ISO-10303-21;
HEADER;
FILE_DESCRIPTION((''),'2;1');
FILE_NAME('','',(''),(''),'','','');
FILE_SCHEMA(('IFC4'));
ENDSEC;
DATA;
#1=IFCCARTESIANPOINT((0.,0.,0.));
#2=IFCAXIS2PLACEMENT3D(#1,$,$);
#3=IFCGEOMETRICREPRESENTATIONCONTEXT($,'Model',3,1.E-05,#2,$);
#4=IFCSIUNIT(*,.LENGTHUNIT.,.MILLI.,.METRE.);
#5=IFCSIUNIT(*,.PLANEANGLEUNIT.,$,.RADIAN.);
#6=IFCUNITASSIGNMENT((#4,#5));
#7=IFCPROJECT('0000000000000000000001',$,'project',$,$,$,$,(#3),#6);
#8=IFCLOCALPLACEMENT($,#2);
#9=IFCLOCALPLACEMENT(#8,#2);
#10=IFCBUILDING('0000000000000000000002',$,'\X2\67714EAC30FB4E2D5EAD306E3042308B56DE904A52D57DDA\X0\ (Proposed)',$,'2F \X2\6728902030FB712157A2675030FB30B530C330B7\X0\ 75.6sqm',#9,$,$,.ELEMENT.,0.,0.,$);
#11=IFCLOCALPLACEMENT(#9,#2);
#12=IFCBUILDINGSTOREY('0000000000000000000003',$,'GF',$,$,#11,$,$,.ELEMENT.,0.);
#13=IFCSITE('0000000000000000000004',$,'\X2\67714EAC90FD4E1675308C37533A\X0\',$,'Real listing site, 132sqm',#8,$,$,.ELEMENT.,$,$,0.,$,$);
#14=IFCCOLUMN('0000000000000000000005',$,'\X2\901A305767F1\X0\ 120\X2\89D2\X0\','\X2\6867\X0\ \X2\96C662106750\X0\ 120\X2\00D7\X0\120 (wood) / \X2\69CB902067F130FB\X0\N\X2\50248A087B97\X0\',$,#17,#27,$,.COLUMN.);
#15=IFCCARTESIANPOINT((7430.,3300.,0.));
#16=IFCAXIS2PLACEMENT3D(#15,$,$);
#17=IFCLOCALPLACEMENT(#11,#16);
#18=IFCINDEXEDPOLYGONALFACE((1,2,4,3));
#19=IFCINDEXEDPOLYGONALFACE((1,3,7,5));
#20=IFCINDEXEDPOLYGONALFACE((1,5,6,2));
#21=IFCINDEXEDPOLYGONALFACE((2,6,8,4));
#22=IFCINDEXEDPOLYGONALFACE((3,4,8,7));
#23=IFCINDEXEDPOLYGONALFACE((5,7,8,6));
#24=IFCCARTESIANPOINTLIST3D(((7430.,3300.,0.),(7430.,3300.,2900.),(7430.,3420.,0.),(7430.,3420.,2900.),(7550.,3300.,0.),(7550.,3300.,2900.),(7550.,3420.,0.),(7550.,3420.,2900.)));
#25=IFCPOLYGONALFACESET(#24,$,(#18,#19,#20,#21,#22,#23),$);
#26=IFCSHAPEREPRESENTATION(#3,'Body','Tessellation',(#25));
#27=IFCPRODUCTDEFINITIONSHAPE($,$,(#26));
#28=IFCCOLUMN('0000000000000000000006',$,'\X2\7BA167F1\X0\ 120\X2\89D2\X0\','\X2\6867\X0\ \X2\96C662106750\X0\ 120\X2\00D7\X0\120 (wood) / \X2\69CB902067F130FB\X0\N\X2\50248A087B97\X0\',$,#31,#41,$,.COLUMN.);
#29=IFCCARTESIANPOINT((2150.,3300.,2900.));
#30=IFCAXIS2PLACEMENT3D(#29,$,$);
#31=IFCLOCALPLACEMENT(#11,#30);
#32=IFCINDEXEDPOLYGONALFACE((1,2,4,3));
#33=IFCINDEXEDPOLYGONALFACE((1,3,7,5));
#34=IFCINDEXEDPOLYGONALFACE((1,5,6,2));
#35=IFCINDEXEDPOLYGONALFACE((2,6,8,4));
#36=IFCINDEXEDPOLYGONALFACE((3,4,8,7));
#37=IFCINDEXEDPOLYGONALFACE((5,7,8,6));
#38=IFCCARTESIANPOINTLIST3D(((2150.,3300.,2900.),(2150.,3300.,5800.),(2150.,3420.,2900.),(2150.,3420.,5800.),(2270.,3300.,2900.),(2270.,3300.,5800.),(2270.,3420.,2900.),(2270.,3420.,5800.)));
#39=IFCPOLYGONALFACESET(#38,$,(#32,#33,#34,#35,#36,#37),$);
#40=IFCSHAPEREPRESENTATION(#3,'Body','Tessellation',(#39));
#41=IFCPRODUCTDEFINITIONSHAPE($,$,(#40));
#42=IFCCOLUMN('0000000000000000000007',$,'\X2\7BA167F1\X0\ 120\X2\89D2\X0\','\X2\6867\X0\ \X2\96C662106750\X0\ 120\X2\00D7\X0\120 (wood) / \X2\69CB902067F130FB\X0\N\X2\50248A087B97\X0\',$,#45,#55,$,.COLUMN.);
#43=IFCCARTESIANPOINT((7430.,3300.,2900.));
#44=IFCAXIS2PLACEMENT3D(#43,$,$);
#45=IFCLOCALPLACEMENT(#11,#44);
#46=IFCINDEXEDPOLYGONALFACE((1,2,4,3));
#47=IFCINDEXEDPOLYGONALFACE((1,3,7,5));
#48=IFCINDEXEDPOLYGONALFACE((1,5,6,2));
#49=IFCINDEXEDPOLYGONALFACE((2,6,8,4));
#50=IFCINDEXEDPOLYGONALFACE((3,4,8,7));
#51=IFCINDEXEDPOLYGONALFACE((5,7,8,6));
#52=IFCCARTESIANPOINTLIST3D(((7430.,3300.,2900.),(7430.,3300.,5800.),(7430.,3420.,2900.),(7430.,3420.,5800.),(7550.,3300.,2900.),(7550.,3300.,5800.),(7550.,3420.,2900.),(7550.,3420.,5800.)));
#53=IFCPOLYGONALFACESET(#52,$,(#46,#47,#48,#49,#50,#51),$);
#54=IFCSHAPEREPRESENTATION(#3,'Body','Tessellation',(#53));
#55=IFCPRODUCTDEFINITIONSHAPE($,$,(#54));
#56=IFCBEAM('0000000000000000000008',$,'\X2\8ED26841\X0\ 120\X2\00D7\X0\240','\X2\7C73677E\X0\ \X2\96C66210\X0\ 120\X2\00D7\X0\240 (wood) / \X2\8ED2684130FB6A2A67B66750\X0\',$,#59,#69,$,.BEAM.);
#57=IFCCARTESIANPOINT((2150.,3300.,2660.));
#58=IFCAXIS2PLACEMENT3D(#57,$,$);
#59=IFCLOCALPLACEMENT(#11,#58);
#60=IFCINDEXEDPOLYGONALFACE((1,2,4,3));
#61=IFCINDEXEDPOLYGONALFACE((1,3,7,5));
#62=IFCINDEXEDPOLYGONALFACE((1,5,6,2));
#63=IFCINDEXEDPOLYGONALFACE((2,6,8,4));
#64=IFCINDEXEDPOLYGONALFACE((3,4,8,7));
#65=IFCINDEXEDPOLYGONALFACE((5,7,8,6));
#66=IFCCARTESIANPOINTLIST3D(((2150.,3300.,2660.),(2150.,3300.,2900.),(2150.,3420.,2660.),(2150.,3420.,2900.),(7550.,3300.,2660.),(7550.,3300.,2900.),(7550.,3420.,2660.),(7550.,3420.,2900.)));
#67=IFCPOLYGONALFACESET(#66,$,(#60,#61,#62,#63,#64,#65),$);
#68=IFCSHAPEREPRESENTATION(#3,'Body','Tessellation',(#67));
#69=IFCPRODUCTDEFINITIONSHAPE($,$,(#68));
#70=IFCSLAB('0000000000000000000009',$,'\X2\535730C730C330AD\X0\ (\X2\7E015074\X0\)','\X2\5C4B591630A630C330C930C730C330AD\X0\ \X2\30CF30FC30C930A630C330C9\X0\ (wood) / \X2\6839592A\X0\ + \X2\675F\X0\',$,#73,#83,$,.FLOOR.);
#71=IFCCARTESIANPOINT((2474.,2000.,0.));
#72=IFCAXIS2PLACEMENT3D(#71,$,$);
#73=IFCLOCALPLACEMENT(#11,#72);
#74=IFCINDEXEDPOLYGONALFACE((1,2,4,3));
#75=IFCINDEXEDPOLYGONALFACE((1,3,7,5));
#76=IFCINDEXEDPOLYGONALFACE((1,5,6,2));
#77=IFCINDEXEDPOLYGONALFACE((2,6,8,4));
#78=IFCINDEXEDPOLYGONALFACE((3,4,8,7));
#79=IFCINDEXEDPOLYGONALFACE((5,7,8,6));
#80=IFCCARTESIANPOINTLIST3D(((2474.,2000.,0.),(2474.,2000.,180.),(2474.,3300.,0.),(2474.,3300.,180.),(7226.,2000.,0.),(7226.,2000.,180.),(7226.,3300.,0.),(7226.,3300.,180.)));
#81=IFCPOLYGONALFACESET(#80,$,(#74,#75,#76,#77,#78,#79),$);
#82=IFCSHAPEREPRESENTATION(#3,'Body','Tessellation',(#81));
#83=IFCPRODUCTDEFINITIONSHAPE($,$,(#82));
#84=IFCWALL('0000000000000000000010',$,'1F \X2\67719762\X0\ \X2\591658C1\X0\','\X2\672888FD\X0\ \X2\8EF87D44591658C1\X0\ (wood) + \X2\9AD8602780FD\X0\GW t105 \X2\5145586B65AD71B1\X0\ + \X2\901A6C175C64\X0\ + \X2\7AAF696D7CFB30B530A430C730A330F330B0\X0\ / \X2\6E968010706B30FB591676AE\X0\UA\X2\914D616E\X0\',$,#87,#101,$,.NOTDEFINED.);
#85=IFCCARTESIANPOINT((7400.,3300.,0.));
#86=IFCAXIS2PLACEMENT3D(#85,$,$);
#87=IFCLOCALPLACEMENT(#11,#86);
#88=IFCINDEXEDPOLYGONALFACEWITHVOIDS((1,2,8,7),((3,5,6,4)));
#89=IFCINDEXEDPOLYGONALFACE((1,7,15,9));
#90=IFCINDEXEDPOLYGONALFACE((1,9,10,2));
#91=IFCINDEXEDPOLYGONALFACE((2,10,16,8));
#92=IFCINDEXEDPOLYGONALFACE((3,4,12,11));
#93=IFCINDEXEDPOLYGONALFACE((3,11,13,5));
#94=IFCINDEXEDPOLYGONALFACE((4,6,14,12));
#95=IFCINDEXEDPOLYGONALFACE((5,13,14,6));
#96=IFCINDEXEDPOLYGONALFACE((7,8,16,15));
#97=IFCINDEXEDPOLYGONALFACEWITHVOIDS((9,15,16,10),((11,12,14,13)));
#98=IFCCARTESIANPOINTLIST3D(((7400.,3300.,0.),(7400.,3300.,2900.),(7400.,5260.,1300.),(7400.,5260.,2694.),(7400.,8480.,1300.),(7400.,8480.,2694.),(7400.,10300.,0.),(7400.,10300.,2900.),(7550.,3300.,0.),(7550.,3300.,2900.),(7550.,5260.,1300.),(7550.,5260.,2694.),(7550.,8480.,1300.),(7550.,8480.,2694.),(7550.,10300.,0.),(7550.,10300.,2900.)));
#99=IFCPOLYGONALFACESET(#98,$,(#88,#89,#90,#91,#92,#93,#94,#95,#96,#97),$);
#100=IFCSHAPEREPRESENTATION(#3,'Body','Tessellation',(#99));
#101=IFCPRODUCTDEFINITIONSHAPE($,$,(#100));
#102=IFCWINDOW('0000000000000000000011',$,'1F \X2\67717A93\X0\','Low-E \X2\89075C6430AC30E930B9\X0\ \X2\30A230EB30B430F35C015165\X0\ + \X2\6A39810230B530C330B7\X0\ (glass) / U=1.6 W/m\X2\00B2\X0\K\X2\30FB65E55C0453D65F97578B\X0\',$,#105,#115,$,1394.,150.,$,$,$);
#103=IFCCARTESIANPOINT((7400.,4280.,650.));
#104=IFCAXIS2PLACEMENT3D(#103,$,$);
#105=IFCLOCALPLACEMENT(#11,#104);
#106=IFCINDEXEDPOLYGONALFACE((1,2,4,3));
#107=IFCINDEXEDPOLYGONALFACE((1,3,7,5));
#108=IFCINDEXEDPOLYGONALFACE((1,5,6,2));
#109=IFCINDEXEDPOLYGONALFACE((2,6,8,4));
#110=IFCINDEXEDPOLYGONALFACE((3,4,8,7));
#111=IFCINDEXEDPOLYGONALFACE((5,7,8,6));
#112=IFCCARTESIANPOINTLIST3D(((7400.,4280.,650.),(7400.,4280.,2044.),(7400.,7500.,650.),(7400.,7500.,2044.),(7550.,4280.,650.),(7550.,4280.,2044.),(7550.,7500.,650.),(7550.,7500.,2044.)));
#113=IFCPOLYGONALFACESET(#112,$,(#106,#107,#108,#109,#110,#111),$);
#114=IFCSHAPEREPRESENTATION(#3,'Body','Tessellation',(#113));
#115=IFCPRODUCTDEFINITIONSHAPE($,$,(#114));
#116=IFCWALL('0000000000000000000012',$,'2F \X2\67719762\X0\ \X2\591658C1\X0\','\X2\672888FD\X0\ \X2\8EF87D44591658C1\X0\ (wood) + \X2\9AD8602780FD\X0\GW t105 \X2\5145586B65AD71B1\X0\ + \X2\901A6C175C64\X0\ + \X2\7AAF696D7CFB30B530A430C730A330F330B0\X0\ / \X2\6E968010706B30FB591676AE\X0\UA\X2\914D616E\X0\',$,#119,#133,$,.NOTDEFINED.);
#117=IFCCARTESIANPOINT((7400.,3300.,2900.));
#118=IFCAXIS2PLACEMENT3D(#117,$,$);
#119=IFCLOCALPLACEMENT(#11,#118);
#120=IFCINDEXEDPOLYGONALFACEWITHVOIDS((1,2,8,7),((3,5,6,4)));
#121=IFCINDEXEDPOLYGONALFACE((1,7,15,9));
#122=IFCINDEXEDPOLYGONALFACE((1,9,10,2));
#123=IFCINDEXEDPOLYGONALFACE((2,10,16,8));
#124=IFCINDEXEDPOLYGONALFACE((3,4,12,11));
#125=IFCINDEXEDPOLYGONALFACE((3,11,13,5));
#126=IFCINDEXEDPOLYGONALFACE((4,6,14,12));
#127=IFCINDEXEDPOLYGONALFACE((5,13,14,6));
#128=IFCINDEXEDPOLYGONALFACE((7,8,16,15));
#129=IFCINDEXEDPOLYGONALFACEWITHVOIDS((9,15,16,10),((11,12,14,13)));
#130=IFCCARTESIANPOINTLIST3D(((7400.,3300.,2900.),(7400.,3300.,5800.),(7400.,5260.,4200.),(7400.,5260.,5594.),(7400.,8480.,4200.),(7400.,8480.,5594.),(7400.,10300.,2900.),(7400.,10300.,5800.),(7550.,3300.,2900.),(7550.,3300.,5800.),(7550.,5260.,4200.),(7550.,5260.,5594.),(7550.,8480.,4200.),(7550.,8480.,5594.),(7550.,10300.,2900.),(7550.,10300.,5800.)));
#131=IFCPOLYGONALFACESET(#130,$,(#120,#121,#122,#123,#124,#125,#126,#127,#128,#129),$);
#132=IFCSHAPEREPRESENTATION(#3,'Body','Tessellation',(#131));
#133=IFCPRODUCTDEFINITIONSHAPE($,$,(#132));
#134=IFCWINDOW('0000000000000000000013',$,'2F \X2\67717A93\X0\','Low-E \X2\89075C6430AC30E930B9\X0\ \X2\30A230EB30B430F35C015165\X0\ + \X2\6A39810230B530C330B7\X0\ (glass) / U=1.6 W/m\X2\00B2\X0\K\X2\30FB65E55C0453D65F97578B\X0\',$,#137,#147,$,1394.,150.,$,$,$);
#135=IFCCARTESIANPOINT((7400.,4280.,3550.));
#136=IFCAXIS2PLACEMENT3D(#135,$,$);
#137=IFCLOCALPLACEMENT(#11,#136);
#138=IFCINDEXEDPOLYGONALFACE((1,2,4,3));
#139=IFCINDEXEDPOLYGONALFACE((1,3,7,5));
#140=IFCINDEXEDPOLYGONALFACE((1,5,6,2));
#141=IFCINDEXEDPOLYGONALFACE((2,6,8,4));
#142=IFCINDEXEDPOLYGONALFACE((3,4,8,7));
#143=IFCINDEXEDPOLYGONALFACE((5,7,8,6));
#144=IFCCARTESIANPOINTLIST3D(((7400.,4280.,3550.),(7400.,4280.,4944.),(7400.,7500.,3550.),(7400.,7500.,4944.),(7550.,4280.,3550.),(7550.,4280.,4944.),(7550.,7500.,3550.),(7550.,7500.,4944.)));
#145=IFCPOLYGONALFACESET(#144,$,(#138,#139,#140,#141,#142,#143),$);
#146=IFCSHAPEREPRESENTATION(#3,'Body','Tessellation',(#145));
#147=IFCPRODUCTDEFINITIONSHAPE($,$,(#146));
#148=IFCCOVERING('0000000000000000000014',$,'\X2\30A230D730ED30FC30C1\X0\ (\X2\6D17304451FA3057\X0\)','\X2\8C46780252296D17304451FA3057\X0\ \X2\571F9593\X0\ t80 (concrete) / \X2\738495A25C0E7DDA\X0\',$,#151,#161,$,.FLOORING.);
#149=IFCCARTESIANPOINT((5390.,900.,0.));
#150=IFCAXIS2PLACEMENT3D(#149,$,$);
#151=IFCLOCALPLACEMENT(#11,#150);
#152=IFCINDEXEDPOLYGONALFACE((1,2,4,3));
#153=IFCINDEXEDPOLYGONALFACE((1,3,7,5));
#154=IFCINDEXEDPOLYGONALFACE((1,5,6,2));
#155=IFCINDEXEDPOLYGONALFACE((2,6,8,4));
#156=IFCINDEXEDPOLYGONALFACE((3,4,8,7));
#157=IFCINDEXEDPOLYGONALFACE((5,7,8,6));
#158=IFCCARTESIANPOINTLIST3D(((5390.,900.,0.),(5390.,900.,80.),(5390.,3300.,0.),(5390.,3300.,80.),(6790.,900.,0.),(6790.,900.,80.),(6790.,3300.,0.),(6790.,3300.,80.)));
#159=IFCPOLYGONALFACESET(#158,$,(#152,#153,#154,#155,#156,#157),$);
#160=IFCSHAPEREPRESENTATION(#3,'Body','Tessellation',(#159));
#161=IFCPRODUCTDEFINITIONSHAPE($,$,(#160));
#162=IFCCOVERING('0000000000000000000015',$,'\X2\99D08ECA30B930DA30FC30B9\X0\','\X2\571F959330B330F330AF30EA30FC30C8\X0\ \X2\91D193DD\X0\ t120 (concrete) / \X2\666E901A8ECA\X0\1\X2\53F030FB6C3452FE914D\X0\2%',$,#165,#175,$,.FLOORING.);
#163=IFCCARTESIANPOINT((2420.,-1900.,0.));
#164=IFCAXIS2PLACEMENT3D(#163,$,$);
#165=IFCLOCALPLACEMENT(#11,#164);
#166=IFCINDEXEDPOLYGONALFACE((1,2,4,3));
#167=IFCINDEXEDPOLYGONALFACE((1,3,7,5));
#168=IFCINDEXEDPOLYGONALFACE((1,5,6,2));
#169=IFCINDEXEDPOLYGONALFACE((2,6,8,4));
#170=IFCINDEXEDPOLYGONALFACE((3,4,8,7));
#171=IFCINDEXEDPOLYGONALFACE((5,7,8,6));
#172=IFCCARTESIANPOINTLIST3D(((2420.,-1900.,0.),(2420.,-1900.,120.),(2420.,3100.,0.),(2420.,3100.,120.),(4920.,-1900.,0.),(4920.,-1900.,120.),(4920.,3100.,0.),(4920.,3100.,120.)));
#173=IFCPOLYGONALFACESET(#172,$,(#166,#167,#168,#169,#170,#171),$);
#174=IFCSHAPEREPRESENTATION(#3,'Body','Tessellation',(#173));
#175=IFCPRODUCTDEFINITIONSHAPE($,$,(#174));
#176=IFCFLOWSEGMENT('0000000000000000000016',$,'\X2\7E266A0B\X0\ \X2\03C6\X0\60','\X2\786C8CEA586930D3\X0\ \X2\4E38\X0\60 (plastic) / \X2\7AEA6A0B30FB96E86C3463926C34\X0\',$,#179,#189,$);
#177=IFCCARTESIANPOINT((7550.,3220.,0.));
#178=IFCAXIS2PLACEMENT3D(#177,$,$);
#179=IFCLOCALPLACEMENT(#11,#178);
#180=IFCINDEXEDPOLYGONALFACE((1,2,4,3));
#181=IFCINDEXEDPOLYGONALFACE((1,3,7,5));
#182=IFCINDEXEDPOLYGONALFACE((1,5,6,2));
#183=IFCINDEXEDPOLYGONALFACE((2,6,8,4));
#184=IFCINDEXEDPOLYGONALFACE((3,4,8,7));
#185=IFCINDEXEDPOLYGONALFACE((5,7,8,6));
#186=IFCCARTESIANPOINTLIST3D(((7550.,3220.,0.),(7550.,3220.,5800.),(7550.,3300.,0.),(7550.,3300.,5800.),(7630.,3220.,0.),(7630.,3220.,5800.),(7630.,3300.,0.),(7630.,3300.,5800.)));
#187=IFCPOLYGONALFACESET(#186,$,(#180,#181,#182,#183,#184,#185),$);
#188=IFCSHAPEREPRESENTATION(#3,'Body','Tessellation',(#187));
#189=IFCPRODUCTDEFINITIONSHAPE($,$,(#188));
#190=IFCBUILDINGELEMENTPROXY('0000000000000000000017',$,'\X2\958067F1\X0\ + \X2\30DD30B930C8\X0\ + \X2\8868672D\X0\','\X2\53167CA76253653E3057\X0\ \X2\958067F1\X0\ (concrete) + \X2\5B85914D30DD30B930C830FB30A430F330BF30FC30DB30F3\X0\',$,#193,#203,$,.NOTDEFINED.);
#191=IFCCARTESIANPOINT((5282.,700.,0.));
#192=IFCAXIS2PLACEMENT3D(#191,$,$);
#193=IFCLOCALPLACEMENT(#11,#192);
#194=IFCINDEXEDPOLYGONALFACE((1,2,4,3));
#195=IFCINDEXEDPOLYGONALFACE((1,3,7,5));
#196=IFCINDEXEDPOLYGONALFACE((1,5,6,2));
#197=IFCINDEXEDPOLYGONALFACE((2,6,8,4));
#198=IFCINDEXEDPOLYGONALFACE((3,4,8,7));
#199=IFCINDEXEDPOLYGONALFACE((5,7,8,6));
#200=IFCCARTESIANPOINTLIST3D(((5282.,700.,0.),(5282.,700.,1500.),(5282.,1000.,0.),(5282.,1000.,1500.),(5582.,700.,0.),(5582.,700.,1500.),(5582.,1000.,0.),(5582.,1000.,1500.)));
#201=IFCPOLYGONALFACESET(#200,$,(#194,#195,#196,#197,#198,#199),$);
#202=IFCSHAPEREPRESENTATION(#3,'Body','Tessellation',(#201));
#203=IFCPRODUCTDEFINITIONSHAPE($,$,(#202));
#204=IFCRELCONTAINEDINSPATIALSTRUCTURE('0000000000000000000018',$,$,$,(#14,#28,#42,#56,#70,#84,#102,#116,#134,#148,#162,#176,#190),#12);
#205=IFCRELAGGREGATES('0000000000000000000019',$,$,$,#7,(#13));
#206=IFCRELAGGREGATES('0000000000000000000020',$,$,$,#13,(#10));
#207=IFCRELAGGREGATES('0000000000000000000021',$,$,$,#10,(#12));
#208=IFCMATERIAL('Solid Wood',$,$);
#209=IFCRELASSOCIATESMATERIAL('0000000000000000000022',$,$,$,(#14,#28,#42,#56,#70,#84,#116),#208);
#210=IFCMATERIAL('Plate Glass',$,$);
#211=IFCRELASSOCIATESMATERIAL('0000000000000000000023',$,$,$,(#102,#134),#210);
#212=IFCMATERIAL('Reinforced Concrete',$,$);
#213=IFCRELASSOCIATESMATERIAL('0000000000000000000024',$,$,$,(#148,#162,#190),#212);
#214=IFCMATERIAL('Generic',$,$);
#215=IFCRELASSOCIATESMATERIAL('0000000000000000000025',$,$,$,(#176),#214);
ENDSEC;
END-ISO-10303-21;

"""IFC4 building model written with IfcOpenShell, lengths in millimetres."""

from ifc_helpers import new_model, si_unit, frame, frame_2d, origin, place, context, project, spatial, rectangle, extrude, material, element, fill, save


model = new_model("IFC4")

# Units and contexts
model_context = context("Model", 3, precision=1e-05, world=origin())
ifc_project = project(units=[si_unit("LENGTHUNIT", "METRE", prefix="MILLI"), si_unit("PLANEANGLEUNIT", "RADIAN")], contexts=[model_context])

# Site, building, storey
site_placement = place(None, origin())
site = spatial("IfcSite", under=ifc_project, at=site_placement, Name="東京都世田谷区", ObjectType="Real listing site, 132sqm", CompositionType="ELEMENT", RefElevation=0.0)
building_placement = place(site_placement, origin())
building = spatial("IfcBuilding", under=site, at=building_placement, Name="東京・中庭のある回遊動線 (Proposed)", ObjectType="2F 木造・無垢材・サッシ 75.6sqm", CompositionType="ELEMENT", ElevationOfRefHeight=0.0, ElevationOfTerrain=0.0)
storey_placement = place(building_placement, origin())
storey = spatial("IfcBuildingStorey", under=building, at=storey_placement, Name="GF", CompositionType="ELEMENT", Elevation=0.0)

# Columns
ifc_material_1 = material(Name="Solid Wood")
column_1_placement = place(storey_placement, frame((7430.0, 3300.0, 0.0)))
element("IfcColumn", 1, at=column_1_placement, inside=storey, material=ifc_material_1, Name="通し柱 120角", Description="桧 集成材 120×120 (wood) / 構造柱・N値計算", PredefinedType="COLUMN", context=model_context, shape_type="SweptSolid", body=[
    extrude(rectangle(XDim=120.0, YDim=120.0, at=frame_2d((60.0, 60.0))), frame((7430.0, 3300.0, 0.0)), (0.0, 0.0, 1.0), 2900.0),
])
column_2_placement = place(storey_placement, frame((2150.0, 3300.0, 2900.0)))
element("IfcColumn", 2, at=column_2_placement, inside=storey, material=ifc_material_1, Name="管柱 120角", Description="桧 集成材 120×120 (wood) / 構造柱・N値計算", PredefinedType="COLUMN", context=model_context, shape_type="SweptSolid", body=[
    extrude(rectangle(XDim=120.0, YDim=120.0, at=frame_2d((60.0, 60.0))), frame((2150.0, 3300.0, 2900.0)), (0.0, 0.0, 1.0), 2900.0),
])
column_3_placement = place(storey_placement, frame((7430.0, 3300.0, 2900.0)))
element("IfcColumn", 3, at=column_3_placement, inside=storey, material=ifc_material_1, Name="管柱 120角", Description="桧 集成材 120×120 (wood) / 構造柱・N値計算", PredefinedType="COLUMN", context=model_context, shape_type="SweptSolid", body=[
    extrude(rectangle(XDim=120.0, YDim=120.0, at=frame_2d((60.0, 60.0))), frame((7430.0, 3300.0, 2900.0)), (0.0, 0.0, 1.0), 2900.0),
])

# Beam
beam_1_placement = place(storey_placement, frame((2150.0, 3300.0, 2660.0)))
element("IfcBeam", 4, at=beam_1_placement, inside=storey, material=ifc_material_1, Name="軒桁 120×240", Description="米松 集成 120×240 (wood) / 軒桁・横架材", PredefinedType="BEAM", context=model_context, shape_type="SweptSolid", body=[
    extrude(rectangle(XDim=5400.0, YDim=120.0, at=frame_2d((2700.0, 60.0))), frame((2150.0, 3300.0, 2660.0)), (0.0, 0.0, 1.0), 240.0),
])

# Slab
slab_placement = place(storey_placement, frame((2474.0, 2000.0, 0.0)))
element("IfcSlab", 5, at=slab_placement, inside=storey, material=ifc_material_1, Name="南デッキ (縁側)", Description="屋外ウッドデッキ ハードウッド (wood) / 根太 + 束", PredefinedType="FLOOR", context=model_context, shape_type="SweptSolid", body=[
    extrude(rectangle(XDim=4752.0, YDim=1300.0, at=frame_2d((2376.0, 650.0))), frame((2474.0, 2000.0, 0.0)), (0.0, 0.0, 1.0), 180.0),
])

# Walls, openings, windows
wall_1_placement = place(storey_placement, frame((7400.0, 3300.0, 0.0)))
wall_1 = element("IfcWall", 6, at=wall_1_placement, inside=storey, material=ifc_material_1, Name="1F 東面 外壁", Description="木製 軸組外壁 (wood) + 高性能GW t105 充填断熱 + 通気層 + 窯業系サイディング / 準耐火・外皮UA配慮", PredefinedType="NOTDEFINED", context=model_context, shape_type="SweptSolid", body=[
    extrude(rectangle(XDim=150.0, YDim=7000.0, at=frame_2d((75.0, 3500.0))), frame((7400.0, 3300.0, 0.0)), (0.0, 0.0, 1.0), 2900.0),
])
opening_1_placement = place(storey_placement, frame((7400.0, 4280.0, 650.0)))
opening_1 = element("IfcOpeningElement", 7, at=opening_1_placement, cuts=wall_1, PredefinedType="NOTDEFINED", context=model_context, shape_type="SweptSolid", body=[
    extrude(rectangle(XDim=150.0, YDim=3220.0, at=frame_2d((75.0, 1610.0))), frame((7400.0, 4280.0, 650.0)), (0.0, 0.0, 1.0), 1394.0),
])
ifc_material_2 = material(Name="Plate Glass")
window_1_placement = place(storey_placement, frame((7400.0, 4280.0, 650.0)))
window_1 = element("IfcWindow", 8, at=window_1_placement, inside=storey, material=ifc_material_2, Name="1F 東窓", Description="Low-E 複層ガラス アルゴン封入 + 樹脂サッシ (glass) / U=1.6 W/m²K・日射取得型", OverallHeight=1394.0, OverallWidth=150.0, context=model_context, shape_type="SweptSolid", body=[
    extrude(rectangle(XDim=150.0, YDim=3220.0, at=frame_2d((75.0, 1610.0))), frame((7400.0, 4280.0, 650.0)), (0.0, 0.0, 1.0), 1394.0),
])
fill(opening_1, window_1)
wall_2_placement = place(storey_placement, frame((7400.0, 3300.0, 2900.0)))
wall_2 = element("IfcWall", 9, at=wall_2_placement, inside=storey, material=ifc_material_1, Name="2F 東面 外壁", Description="木製 軸組外壁 (wood) + 高性能GW t105 充填断熱 + 通気層 + 窯業系サイディング / 準耐火・外皮UA配慮", PredefinedType="NOTDEFINED", context=model_context, shape_type="SweptSolid", body=[
    extrude(rectangle(XDim=150.0, YDim=7000.0, at=frame_2d((75.0, 3500.0))), frame((7400.0, 3300.0, 2900.0)), (0.0, 0.0, 1.0), 2900.0),
])
opening_2_placement = place(storey_placement, frame((7400.0, 4280.0, 3550.0)))
opening_2 = element("IfcOpeningElement", 10, at=opening_2_placement, cuts=wall_2, PredefinedType="NOTDEFINED", context=model_context, shape_type="SweptSolid", body=[
    extrude(rectangle(XDim=150.0, YDim=3220.0, at=frame_2d((75.0, 1610.0))), frame((7400.0, 4280.0, 3550.0)), (0.0, 0.0, 1.0), 1394.0),
])
window_2_placement = place(storey_placement, frame((7400.0, 4280.0, 3550.0)))
window_2 = element("IfcWindow", 11, at=window_2_placement, inside=storey, material=ifc_material_2, Name="2F 東窓", Description="Low-E 複層ガラス アルゴン封入 + 樹脂サッシ (glass) / U=1.6 W/m²K・日射取得型", OverallHeight=1394.0, OverallWidth=150.0, context=model_context, shape_type="SweptSolid", body=[
    extrude(rectangle(XDim=150.0, YDim=3220.0, at=frame_2d((75.0, 1610.0))), frame((7400.0, 4280.0, 3550.0)), (0.0, 0.0, 1.0), 1394.0),
])
fill(opening_2, window_2)

# Coverings
ifc_material_3 = material(Name="Reinforced Concrete")
covering_1_placement = place(storey_placement, frame((5390.0, 900.0, 0.0)))
element("IfcCovering", 12, at=covering_1_placement, inside=storey, material=ifc_material_3, Name="アプローチ (洗い出し)", Description="豆砂利洗い出し 土間 t80 (concrete) / 玄関導線", PredefinedType="FLOORING", context=model_context, shape_type="SweptSolid", body=[
    extrude(rectangle(XDim=1400.0, YDim=2400.0, at=frame_2d((700.0, 1200.0))), frame((5390.0, 900.0, 0.0)), (0.0, 0.0, 1.0), 80.0),
])
covering_2_placement = place(storey_placement, frame((2420.0, -1900.0, 0.0)))
element("IfcCovering", 13, at=covering_2_placement, inside=storey, material=ifc_material_3, Name="駐車スペース", Description="土間コンクリート 金鏝 t120 (concrete) / 普通車1台・水勾配2%", PredefinedType="FLOORING", context=model_context, shape_type="SweptSolid", body=[
    extrude(rectangle(XDim=2500.0, YDim=5000.0, at=frame_2d((1250.0, 2500.0))), frame((2420.0, -1900.0, 0.0)), (0.0, 0.0, 1.0), 120.0),
])

# Flow segment
ifc_material_4 = material(Name="Generic")
flow_segment_placement = place(storey_placement, frame((7550.0, 3220.0, 0.0)))
element("IfcFlowSegment", 14, at=flow_segment_placement, inside=storey, material=ifc_material_4, Name="縦樋 φ60", Description="硬質塩ビ 丸60 (plastic) / 竪樋・雨水排水", context=model_context, shape_type="SweptSolid", body=[
    extrude(rectangle(XDim=80.0, YDim=80.0, at=frame_2d((40.0, 40.0))), frame((7550.0, 3220.0, 0.0)), (0.0, 0.0, 1.0), 5800.0),
])

# Building element proxy
proxy_placement = place(storey_placement, frame((5282.0, 700.0, 0.0)))
element("IfcBuildingElementProxy", 15, at=proxy_placement, inside=storey, material=ifc_material_3, Name="門柱 + ポスト + 表札", Description="化粧打放し 門柱 (concrete) + 宅配ポスト・インターホン", PredefinedType="NOTDEFINED", context=model_context, shape_type="SweptSolid", body=[
    extrude(rectangle(XDim=300.0, YDim=300.0, at=frame_2d((150.0, 150.0))), frame((5282.0, 700.0, 0.0)), (0.0, 0.0, 1.0), 1500.0),
])

save(model, "model.ifc")
